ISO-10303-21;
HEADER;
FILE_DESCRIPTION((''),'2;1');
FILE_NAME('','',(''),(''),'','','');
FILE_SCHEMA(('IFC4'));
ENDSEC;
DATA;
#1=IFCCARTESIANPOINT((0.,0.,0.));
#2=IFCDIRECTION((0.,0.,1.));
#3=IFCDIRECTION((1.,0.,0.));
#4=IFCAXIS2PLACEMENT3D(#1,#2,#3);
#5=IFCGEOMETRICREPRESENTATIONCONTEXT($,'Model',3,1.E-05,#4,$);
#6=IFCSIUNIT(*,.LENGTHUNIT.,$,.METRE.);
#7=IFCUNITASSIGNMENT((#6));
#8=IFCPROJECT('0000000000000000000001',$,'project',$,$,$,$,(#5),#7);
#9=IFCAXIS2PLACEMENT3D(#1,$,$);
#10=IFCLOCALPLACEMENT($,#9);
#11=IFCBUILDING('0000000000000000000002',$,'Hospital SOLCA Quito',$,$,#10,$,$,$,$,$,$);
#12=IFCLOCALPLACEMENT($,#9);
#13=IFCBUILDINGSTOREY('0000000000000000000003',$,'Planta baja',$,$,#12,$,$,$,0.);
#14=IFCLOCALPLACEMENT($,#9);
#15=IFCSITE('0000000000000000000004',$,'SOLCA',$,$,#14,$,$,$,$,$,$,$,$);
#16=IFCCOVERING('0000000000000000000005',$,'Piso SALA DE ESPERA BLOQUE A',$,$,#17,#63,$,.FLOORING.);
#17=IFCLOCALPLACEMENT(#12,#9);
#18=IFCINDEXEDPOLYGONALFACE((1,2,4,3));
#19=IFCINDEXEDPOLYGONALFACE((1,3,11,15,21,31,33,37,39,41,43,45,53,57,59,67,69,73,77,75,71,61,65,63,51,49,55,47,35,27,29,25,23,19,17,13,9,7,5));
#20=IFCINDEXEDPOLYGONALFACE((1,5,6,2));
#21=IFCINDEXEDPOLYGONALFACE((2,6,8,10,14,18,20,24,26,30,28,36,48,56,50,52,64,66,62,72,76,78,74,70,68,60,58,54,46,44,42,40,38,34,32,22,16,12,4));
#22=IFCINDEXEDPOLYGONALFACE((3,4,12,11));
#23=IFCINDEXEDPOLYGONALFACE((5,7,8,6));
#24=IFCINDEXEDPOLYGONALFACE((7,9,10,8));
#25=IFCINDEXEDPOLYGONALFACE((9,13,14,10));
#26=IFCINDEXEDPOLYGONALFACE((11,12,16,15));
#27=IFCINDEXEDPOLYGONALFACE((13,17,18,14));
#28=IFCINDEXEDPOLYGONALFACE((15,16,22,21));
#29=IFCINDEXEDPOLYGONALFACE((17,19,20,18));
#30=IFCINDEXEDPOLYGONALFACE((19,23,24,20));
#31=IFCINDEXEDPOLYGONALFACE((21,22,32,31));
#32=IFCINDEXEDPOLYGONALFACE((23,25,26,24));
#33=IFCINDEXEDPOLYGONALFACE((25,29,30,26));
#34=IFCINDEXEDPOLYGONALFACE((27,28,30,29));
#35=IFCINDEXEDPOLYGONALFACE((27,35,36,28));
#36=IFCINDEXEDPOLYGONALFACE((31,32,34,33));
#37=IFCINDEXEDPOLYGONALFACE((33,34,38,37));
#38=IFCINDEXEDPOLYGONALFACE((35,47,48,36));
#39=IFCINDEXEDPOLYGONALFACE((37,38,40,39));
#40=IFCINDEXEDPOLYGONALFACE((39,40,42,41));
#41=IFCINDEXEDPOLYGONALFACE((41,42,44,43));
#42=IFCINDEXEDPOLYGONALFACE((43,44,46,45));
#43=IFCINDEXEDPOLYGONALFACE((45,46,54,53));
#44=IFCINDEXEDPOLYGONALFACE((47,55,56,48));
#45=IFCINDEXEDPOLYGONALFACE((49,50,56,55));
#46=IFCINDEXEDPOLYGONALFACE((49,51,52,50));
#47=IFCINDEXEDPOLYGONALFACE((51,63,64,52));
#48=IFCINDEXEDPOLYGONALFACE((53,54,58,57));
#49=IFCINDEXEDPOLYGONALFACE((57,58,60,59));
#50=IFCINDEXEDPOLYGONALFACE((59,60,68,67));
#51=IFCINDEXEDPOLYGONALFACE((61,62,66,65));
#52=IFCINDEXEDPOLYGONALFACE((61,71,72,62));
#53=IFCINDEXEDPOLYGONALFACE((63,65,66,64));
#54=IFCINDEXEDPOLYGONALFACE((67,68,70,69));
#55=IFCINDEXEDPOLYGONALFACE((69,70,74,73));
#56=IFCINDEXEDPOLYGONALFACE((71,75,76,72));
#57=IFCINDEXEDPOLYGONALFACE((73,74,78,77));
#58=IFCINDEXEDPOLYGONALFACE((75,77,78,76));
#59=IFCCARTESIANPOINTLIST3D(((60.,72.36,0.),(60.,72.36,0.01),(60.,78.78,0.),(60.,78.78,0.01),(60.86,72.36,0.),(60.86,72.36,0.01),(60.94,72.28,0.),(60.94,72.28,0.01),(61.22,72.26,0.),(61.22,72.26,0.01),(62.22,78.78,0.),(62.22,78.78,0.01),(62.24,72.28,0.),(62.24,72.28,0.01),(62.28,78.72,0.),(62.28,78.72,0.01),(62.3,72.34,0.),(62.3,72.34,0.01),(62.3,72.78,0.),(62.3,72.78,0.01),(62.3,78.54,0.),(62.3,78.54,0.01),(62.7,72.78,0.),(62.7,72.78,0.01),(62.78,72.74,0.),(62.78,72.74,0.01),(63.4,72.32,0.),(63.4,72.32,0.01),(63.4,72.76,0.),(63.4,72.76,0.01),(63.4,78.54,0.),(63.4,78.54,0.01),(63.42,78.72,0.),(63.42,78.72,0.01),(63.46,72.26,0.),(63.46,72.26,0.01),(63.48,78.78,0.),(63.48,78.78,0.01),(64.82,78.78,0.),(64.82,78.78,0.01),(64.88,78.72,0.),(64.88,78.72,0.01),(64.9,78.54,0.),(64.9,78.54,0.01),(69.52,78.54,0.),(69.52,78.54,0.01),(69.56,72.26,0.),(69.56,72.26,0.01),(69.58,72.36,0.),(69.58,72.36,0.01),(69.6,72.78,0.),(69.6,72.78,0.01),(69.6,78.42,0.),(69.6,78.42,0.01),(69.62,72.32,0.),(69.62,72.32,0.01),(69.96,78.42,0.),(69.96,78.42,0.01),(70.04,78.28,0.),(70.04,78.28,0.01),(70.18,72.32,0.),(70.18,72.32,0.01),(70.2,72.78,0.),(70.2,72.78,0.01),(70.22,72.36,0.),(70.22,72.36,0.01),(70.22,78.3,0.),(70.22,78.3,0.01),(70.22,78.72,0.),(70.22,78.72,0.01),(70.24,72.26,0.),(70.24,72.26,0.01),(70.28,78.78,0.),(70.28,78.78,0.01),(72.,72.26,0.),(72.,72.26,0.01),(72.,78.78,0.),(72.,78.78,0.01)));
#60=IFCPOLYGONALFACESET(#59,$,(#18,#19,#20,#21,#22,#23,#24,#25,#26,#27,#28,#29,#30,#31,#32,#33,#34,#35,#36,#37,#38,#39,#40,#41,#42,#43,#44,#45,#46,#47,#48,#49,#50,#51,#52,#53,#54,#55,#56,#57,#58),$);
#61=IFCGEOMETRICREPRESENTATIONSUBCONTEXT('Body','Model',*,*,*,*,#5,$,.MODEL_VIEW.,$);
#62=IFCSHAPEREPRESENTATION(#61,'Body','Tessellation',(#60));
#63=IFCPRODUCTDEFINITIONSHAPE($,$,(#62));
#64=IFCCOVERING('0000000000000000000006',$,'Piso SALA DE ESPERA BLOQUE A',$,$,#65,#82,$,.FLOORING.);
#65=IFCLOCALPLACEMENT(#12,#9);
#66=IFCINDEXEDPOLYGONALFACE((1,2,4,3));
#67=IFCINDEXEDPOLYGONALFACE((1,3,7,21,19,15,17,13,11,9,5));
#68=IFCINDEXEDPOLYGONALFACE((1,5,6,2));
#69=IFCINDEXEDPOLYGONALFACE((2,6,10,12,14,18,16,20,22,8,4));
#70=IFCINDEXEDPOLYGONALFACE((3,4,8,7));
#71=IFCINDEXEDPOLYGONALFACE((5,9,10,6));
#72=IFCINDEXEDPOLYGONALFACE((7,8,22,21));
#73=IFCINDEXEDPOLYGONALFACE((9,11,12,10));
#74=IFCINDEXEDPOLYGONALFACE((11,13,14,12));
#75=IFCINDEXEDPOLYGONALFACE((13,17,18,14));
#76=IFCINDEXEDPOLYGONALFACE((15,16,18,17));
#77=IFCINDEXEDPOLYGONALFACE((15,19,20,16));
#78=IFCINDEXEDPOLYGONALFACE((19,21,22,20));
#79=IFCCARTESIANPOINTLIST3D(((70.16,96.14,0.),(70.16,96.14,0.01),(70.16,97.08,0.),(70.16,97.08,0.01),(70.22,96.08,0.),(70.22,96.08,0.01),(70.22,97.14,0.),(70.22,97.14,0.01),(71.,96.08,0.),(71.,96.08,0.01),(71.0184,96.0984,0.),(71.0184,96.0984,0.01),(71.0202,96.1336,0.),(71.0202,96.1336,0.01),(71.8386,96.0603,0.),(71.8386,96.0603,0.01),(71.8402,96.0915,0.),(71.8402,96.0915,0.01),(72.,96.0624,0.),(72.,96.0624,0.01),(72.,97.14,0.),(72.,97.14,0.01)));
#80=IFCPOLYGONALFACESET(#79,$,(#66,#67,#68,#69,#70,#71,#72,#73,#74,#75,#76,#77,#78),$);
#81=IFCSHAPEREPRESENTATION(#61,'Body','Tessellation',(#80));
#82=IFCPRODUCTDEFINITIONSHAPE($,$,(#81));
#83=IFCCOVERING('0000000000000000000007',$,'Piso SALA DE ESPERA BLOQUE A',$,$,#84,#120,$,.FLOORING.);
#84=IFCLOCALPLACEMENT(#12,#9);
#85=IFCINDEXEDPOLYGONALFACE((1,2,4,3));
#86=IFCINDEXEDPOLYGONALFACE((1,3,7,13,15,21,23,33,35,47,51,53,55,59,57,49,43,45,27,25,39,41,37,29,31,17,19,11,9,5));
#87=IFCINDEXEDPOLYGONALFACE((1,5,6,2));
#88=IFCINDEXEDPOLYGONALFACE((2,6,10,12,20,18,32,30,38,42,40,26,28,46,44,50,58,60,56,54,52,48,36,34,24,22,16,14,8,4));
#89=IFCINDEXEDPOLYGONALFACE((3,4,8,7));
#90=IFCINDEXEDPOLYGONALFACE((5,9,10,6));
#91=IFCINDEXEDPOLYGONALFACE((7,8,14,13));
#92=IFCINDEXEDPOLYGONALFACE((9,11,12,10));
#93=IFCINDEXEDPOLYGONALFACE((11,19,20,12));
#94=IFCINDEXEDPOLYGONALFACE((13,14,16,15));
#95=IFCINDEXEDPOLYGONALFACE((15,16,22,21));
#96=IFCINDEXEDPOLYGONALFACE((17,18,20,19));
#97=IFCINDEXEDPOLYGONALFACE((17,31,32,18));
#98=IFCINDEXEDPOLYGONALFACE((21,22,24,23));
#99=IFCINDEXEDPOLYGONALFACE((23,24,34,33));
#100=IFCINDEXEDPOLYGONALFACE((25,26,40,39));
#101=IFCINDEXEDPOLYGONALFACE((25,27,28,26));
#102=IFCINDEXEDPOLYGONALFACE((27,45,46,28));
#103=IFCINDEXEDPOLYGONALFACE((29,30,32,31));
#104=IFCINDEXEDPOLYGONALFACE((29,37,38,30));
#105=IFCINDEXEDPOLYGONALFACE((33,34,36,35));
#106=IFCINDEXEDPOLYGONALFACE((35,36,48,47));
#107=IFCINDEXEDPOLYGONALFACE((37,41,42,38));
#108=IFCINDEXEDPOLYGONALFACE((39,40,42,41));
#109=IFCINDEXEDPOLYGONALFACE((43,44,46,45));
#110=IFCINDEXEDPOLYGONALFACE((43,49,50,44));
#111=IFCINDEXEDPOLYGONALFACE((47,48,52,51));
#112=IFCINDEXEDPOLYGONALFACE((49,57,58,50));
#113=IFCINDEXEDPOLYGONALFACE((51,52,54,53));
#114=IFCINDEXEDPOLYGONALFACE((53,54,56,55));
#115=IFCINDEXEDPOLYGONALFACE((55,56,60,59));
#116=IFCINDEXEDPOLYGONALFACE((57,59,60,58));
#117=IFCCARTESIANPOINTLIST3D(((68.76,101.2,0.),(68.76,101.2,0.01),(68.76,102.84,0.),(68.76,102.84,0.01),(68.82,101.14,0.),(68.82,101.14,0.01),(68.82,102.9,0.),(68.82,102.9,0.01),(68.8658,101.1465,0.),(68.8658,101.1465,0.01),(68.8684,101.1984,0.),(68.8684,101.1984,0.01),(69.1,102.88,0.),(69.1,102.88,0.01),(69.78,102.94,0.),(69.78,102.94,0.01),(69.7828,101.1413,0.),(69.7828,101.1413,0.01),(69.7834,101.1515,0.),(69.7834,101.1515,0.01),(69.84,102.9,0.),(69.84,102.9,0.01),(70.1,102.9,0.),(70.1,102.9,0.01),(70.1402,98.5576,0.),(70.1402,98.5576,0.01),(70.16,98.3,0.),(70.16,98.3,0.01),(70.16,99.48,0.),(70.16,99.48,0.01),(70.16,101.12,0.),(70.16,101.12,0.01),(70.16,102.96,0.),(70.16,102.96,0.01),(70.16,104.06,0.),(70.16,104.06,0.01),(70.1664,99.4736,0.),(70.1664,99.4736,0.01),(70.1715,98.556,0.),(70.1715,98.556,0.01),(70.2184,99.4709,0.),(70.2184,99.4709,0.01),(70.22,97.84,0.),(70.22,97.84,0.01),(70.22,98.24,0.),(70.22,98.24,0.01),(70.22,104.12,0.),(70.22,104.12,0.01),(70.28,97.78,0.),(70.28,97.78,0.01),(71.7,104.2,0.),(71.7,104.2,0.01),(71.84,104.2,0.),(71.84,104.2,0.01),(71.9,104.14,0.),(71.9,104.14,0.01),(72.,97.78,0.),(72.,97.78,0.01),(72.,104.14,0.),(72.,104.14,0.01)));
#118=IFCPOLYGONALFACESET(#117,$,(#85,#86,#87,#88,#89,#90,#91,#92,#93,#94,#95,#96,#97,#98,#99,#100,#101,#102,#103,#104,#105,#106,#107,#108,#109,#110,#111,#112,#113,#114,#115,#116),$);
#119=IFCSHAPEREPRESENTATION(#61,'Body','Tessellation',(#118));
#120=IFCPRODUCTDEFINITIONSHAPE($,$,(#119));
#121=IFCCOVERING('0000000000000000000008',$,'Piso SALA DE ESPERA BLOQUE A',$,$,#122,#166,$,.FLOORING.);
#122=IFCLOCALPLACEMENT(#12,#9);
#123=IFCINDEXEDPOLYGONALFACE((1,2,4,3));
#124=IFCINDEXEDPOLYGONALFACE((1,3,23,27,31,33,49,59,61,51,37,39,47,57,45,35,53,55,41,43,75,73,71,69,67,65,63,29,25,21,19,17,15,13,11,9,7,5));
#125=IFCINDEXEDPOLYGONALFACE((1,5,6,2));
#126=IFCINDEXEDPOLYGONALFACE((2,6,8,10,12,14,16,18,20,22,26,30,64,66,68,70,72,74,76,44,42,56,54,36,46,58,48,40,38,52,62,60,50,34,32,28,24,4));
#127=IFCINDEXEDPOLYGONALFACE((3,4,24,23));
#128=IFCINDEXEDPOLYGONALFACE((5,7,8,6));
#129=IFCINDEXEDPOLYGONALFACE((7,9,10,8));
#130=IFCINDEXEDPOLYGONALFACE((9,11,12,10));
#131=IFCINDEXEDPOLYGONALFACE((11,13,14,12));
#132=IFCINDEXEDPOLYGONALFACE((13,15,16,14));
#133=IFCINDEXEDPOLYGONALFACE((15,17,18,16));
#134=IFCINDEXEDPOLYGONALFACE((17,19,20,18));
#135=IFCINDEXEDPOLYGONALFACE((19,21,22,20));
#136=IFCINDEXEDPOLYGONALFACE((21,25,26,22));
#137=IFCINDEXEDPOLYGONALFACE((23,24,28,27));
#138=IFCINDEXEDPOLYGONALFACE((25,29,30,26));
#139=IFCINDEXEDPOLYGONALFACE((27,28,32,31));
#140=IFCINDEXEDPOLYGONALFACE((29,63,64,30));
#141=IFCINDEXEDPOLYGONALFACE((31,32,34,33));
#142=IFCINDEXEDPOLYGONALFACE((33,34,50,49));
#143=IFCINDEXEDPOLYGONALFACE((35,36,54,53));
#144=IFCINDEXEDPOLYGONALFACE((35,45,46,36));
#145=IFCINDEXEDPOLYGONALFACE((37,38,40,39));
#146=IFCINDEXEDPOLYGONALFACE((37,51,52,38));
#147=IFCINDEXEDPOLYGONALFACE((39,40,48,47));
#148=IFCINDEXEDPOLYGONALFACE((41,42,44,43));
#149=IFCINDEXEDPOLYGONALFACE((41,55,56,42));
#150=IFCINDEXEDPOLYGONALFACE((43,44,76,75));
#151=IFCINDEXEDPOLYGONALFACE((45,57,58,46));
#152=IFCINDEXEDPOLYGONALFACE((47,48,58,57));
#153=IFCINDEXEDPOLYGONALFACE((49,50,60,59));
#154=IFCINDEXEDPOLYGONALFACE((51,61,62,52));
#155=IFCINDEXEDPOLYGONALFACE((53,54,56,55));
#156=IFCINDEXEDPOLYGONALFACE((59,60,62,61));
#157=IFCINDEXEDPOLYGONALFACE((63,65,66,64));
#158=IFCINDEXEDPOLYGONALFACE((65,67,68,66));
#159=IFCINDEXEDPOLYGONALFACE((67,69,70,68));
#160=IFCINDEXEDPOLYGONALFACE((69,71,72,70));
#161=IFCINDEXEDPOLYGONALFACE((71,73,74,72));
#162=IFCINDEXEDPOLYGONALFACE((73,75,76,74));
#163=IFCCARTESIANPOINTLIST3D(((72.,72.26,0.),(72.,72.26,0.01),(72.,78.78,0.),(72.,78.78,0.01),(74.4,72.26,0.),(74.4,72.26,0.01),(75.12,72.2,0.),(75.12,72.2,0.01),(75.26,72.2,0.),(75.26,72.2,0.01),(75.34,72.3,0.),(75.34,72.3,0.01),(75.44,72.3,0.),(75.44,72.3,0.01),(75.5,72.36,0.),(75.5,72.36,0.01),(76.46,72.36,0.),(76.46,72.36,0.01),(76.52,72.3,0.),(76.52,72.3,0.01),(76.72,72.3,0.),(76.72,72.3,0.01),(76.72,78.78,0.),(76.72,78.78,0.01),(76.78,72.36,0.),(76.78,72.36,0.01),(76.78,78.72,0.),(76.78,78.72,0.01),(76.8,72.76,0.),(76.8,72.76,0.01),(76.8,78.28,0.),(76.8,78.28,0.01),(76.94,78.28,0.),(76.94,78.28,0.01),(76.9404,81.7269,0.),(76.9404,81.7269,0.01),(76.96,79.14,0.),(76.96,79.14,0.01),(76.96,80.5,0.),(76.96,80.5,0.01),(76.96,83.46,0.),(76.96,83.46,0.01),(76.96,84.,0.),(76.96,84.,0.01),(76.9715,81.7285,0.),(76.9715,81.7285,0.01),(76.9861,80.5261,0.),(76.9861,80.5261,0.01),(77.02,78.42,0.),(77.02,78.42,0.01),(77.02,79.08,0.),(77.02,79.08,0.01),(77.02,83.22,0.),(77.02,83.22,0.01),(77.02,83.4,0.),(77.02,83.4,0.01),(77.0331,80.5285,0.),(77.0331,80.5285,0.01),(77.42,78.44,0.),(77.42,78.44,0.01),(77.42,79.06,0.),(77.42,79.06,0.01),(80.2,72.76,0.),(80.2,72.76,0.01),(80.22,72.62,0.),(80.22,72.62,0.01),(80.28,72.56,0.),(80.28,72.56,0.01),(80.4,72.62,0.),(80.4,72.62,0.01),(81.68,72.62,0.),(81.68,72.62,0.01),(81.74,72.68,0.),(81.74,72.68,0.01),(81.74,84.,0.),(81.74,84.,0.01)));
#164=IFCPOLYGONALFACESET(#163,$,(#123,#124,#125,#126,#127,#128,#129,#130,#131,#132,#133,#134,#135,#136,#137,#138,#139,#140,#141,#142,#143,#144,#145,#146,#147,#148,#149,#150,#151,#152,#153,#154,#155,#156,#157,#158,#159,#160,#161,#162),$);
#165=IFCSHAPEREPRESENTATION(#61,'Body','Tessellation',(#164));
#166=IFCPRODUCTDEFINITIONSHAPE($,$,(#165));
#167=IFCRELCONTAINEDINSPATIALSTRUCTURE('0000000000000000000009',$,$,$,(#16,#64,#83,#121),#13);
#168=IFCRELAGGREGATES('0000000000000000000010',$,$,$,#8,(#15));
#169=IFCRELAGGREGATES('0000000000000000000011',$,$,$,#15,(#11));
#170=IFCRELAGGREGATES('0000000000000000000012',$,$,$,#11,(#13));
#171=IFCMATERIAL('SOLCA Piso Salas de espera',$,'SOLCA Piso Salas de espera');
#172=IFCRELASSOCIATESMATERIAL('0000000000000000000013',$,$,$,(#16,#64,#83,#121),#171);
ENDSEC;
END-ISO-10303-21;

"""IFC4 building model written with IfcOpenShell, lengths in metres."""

from ifc_helpers import new_model, si_unit, origin, origin_with_axes, place, context, subcontext, project, spatial, polyline, outline, extrude, material, element, save


model = new_model("IFC4")

# Units and contexts
model_context = context("Model", 3, precision=1e-05, world=origin_with_axes())
body_context = subcontext(model_context, "Body", "Model", "MODEL_VIEW")
ifc_project = project(units=[si_unit("LENGTHUNIT", "METRE")], contexts=[model_context])

# Site, building, storey
site_placement = place(None, origin())
site = spatial("IfcSite", under=ifc_project, at=site_placement, Name="SOLCA")
building_placement = place(None, origin())
building = spatial("IfcBuilding", under=site, at=building_placement, Name="Hospital SOLCA Quito")
storey_placement = place(None, origin())
storey = spatial("IfcBuildingStorey", under=building, at=storey_placement, Name="Planta baja", Elevation=0.0)

# Coverings
ifc_material_1 = material(Name="SOLCA Piso Salas de espera", Category="SOLCA Piso Salas de espera")
covering_1_placement = place(storey_placement, origin_with_axes())
element("IfcCovering", 1, at=covering_1_placement, inside=storey, material=ifc_material_1, Name="Piso SALA DE ESPERA BLOQUE A", PredefinedType="FLOORING", context=body_context, shape_type="SweptSolid", body=[
    extrude(outline(polyline([(70.24, 72.26), (70.18, 72.32), (70.22, 72.36), (70.2, 72.78), (69.6, 72.78), (69.58, 72.36), (69.62, 72.32), (69.56, 72.26), (63.46, 72.26), (63.4, 72.32), (63.4, 72.76), (62.78, 72.74), (62.7, 72.78), (62.3, 72.78), (62.3, 72.34), (62.24, 72.28), (61.22, 72.26), (60.94, 72.28), (60.86, 72.36), (60.0, 72.36), (60.0, 78.78), (62.22, 78.78), (62.28, 78.72), (62.3, 78.54), (63.4, 78.54), (63.42, 78.72), (63.48, 78.78), (64.82, 78.78), (64.88, 78.72), (64.9, 78.54), (69.52, 78.54), (69.6, 78.42), (69.96, 78.42), (70.04, 78.28), (70.22, 78.3), (70.22, 78.72), (70.28, 78.78), (72.0, 78.78), (72.0, 72.26), (70.24, 72.26)])), origin_with_axes(), (0.0, 0.0, 1.0), 0.01),
])
covering_2_placement = place(storey_placement, origin_with_axes())
element("IfcCovering", 2, at=covering_2_placement, inside=storey, material=ifc_material_1, Name="Piso SALA DE ESPERA BLOQUE A", PredefinedType="FLOORING", context=body_context, shape_type="SweptSolid", body=[
    extrude(outline(polyline([(71.8386, 96.0603), (71.8402, 96.0915), (71.0202, 96.1336), (71.0184, 96.0984), (71.0, 96.08), (70.22, 96.08), (70.16, 96.14), (70.16, 97.08), (70.22, 97.14), (72.0, 97.14), (72.0, 96.0624), (71.8386, 96.0603)])), origin_with_axes(), (0.0, 0.0, 1.0), 0.01),
])
covering_3_placement = place(storey_placement, origin_with_axes())
element("IfcCovering", 3, at=covering_3_placement, inside=storey, material=ifc_material_1, Name="Piso SALA DE ESPERA BLOQUE A", PredefinedType="FLOORING", context=body_context, shape_type="SweptSolid", body=[
    extrude(outline(polyline([(70.28, 97.78), (70.22, 97.84), (70.22, 98.24), (70.16, 98.3), (70.1402, 98.5576), (70.1715, 98.556), (70.2184, 99.4709), (70.1664, 99.4736), (70.16, 99.48), (70.16, 101.12), (69.7828, 101.1413), (69.7834, 101.1515), (68.8684, 101.1984), (68.8658, 101.1465), (68.82, 101.14), (68.76, 101.2), (68.76, 102.84), (68.82, 102.9), (69.1, 102.88), (69.78, 102.94), (69.84, 102.9), (70.1, 102.9), (70.16, 102.96), (70.16, 104.06), (70.22, 104.12), (71.7, 104.2), (71.84, 104.2), (71.9, 104.14), (72.0, 104.14), (72.0, 97.78), (70.28, 97.78)])), origin_with_axes(), (0.0, 0.0, 1.0), 0.01),
])
covering_4_placement = place(storey_placement, origin_with_axes())
element("IfcCovering", 4, at=covering_4_placement, inside=storey, material=ifc_material_1, Name="Piso SALA DE ESPERA BLOQUE A", PredefinedType="FLOORING", context=body_context, shape_type="SweptSolid", body=[
    extrude(outline(polyline([(76.8, 72.76), (76.78, 72.36), (76.72, 72.3), (76.52, 72.3), (76.46, 72.36), (75.5, 72.36), (75.44, 72.3), (75.34, 72.3), (75.26, 72.2), (75.12, 72.2), (74.4, 72.26), (72.0, 72.26), (72.0, 78.78), (76.72, 78.78), (76.78, 78.72), (76.8, 78.28), (76.94, 78.28), (77.02, 78.42), (77.42, 78.44), (77.42, 79.06), (77.02, 79.08), (76.96, 79.14), (76.96, 80.5), (76.9861, 80.5261), (77.0331, 80.5285), (76.9715, 81.7285), (76.9404, 81.7269), (77.02, 83.22), (77.02, 83.4), (76.96, 83.46), (76.96, 84.0), (81.74, 84.0), (81.74, 72.68), (81.68, 72.62), (80.4, 72.62), (80.28, 72.56), (80.22, 72.62), (80.2, 72.76), (76.8, 72.76)])), origin_with_axes(), (0.0, 0.0, 1.0), 0.01),
])

save(model, "model.ifc")
